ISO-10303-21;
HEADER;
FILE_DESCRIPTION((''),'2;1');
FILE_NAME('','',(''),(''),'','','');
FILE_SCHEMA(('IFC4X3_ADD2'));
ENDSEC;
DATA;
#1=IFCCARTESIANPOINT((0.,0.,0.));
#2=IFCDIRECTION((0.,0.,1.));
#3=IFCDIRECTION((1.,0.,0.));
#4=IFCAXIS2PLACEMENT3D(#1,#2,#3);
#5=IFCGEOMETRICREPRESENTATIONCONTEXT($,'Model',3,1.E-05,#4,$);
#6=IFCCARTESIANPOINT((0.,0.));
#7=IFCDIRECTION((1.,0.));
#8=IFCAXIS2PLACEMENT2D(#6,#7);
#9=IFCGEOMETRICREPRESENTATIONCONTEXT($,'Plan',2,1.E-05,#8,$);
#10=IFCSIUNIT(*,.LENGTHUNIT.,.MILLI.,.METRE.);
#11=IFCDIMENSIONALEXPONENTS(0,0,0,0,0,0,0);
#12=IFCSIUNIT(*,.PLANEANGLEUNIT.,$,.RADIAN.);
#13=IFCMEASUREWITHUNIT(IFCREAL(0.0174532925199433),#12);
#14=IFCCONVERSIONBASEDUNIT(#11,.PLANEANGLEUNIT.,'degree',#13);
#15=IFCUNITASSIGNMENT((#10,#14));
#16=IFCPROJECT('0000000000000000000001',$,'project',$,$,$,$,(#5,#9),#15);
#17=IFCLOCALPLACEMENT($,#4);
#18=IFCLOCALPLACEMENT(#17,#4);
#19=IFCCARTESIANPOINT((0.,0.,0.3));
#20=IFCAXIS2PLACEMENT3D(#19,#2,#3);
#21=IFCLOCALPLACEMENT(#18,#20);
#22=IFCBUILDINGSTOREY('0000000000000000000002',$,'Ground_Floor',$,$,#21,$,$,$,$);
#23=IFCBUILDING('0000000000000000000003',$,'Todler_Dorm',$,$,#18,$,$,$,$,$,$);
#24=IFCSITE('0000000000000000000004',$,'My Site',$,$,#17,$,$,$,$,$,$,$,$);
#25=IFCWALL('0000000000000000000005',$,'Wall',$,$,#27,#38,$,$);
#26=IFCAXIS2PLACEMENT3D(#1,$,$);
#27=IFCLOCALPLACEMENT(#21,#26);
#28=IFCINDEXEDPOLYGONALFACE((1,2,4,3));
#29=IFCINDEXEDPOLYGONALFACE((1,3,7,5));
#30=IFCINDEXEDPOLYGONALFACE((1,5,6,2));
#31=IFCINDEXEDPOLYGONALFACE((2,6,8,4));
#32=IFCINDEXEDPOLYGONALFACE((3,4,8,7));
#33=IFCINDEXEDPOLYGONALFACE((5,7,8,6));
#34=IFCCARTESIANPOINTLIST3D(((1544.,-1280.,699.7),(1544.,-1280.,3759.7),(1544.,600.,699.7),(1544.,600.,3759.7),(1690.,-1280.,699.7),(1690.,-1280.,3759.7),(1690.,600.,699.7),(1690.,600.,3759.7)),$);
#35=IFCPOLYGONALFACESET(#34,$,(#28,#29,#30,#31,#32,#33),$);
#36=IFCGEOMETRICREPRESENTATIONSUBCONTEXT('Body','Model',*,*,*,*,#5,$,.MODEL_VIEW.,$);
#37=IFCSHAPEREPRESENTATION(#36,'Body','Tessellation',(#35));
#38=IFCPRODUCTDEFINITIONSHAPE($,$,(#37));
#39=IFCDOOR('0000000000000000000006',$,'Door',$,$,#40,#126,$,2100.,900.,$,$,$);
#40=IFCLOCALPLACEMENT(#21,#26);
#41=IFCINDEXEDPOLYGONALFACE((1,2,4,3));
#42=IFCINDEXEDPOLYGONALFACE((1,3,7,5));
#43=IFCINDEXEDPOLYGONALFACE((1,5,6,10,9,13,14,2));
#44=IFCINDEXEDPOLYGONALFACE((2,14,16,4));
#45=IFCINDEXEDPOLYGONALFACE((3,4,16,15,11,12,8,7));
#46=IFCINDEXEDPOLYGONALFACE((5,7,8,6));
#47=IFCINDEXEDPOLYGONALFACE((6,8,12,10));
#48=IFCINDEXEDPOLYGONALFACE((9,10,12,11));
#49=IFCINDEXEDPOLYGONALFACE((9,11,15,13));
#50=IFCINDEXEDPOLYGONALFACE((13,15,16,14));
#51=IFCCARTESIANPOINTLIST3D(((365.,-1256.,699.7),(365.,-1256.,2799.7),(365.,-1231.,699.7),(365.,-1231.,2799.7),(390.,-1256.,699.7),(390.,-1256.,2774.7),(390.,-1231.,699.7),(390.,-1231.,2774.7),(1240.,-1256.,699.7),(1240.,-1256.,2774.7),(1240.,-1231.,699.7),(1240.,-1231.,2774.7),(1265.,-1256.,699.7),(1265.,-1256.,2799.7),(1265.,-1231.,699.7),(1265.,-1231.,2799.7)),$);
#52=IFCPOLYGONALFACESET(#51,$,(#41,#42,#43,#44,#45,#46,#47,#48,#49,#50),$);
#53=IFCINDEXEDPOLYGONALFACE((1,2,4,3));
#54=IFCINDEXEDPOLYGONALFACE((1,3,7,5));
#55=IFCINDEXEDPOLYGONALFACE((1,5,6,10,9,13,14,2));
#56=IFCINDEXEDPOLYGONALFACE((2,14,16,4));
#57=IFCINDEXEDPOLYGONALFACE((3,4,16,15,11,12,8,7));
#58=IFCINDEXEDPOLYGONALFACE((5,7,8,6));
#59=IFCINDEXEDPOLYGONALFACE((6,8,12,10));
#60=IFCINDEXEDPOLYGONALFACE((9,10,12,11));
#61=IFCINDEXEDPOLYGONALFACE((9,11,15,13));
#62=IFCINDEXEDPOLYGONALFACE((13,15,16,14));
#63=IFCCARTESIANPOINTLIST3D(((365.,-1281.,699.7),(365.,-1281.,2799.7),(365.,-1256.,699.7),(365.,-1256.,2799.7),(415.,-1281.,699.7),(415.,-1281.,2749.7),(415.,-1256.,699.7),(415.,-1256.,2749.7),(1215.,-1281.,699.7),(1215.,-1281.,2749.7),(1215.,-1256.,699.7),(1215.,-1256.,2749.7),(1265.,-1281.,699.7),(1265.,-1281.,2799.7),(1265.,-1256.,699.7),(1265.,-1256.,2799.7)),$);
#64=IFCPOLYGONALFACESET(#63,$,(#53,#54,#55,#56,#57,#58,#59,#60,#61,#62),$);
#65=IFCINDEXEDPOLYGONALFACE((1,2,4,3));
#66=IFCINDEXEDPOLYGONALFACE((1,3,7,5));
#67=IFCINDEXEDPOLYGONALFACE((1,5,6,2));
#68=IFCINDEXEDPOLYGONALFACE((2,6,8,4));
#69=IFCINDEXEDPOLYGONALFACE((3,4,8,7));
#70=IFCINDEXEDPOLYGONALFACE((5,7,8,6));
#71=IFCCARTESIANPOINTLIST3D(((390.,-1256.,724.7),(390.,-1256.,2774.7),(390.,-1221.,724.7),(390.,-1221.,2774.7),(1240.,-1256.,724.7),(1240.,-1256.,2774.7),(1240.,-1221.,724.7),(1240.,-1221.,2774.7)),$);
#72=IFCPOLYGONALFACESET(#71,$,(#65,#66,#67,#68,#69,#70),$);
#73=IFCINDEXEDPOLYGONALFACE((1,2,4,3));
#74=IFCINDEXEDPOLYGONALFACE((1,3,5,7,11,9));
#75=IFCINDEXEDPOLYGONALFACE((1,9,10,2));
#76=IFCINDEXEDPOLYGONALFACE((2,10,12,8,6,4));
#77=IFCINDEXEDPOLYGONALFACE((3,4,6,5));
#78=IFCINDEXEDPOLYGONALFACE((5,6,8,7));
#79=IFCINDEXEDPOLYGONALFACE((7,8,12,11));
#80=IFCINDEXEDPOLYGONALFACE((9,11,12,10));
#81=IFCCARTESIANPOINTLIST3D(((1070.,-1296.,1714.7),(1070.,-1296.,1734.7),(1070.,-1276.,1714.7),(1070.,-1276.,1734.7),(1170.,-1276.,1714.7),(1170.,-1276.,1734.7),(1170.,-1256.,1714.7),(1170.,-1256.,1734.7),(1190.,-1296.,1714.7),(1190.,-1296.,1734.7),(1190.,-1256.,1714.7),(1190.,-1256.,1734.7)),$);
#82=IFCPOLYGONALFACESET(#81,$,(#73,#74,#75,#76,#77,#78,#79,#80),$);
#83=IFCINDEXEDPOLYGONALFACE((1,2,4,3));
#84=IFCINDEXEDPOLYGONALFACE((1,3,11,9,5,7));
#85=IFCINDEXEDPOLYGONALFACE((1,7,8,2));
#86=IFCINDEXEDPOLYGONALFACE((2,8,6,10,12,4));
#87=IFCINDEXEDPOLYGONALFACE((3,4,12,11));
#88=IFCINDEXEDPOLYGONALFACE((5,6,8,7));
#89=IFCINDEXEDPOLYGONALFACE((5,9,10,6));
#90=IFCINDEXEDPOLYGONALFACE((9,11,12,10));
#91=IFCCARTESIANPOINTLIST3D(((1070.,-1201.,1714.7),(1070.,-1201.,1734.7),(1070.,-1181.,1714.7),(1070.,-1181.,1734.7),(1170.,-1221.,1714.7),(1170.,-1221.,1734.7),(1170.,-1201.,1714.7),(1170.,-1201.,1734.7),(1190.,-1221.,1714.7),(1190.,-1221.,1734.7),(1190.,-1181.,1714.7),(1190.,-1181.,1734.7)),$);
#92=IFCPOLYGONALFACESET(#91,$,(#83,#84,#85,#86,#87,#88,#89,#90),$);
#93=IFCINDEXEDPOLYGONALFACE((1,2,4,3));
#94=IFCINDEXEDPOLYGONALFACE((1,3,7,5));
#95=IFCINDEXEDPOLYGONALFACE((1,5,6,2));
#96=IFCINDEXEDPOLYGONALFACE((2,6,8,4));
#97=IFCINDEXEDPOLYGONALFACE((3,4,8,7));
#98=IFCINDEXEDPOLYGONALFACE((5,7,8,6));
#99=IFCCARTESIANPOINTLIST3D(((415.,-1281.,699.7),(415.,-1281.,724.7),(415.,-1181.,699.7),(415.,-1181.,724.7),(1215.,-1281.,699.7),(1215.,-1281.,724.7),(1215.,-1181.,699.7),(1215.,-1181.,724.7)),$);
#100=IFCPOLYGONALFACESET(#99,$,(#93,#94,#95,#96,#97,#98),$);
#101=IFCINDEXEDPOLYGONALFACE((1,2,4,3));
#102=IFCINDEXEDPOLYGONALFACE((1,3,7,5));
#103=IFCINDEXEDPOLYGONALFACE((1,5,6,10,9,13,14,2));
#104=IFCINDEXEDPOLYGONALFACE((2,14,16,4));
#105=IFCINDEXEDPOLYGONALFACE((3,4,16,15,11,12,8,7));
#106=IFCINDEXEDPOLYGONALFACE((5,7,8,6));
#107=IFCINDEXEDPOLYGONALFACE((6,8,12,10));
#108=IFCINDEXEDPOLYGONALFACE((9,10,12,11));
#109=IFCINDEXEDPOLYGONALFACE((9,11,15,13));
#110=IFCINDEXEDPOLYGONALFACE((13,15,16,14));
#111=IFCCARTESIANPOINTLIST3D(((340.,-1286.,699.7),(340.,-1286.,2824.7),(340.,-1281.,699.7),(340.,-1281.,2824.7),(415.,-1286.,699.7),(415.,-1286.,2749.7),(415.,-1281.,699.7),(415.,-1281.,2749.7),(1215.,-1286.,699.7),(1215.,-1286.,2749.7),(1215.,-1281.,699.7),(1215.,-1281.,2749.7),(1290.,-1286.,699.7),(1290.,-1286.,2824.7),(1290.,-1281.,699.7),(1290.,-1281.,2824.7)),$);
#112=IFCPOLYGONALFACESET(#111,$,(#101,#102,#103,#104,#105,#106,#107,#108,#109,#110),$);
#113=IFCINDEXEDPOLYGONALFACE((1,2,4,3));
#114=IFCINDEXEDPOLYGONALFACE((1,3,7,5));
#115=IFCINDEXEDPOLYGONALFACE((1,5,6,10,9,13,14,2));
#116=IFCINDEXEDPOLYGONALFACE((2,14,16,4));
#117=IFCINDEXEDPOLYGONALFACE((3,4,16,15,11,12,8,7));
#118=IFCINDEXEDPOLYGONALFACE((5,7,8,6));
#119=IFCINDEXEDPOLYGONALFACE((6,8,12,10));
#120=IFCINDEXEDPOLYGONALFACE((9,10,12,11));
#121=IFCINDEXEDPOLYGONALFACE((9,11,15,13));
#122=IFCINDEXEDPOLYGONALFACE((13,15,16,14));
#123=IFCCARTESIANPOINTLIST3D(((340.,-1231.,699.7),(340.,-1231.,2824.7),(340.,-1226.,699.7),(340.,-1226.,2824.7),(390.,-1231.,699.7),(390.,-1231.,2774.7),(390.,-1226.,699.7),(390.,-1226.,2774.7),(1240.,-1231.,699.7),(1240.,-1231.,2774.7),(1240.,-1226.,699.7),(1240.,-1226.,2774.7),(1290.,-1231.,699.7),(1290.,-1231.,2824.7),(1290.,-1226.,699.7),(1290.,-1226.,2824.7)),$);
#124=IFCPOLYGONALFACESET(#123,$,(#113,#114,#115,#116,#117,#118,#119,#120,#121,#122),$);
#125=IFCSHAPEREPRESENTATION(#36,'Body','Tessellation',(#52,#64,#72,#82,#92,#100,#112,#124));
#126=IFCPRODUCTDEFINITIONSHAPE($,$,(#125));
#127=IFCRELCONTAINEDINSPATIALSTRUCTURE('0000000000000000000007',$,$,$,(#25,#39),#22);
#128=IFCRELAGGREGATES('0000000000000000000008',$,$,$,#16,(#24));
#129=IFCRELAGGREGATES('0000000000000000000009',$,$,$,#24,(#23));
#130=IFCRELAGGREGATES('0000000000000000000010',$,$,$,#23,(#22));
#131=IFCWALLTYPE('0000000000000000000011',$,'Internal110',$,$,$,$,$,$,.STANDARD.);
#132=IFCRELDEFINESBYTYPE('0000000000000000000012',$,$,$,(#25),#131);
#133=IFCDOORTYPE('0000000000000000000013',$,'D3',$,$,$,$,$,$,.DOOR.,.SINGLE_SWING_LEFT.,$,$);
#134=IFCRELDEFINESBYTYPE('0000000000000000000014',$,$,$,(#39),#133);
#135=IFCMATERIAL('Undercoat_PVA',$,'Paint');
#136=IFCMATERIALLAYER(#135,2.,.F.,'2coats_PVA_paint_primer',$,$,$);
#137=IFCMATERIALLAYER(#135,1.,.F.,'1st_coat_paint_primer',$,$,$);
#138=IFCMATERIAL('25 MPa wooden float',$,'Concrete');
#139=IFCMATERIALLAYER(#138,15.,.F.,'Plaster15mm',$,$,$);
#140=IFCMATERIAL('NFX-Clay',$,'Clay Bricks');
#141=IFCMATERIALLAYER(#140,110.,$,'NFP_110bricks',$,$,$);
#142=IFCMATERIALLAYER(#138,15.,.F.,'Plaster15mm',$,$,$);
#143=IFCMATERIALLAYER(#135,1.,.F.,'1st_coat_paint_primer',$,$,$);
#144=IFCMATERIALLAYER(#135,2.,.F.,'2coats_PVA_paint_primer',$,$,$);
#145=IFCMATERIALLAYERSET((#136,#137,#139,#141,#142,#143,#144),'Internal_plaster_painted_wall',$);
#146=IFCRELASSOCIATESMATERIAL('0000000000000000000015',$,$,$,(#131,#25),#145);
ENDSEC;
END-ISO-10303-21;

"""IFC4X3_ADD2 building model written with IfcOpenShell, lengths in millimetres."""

from ifc_helpers import new_model, entity, si_unit, converted_unit, frame, origin_with_axes, origin_2d_with_axis, place, context, subcontext, project, spatial, line, indexed_curve, outline, extrude, shape, source, transform, mapped, material, layer, layer_set, layer_usage, type_object, type_shapes, element, save


model = new_model("IFC4X3_ADD2")

# Units and contexts
model_context = context("Model", 3, precision=1e-05, world=origin_with_axes())
plan_context = context("Plan", 2, precision=1e-05, world=origin_2d_with_axis())
body_context_1 = subcontext(model_context, "Body", "Model", "MODEL_VIEW")
body_context_2 = subcontext(plan_context, "Body", "Plan", "PLAN_VIEW")
ifc_project = project(units=[si_unit("LENGTHUNIT", "METRE", prefix="MILLI"), converted_unit("PLANEANGLEUNIT", "degree", entity("IfcReal", 0.0174532925199433), si_unit("PLANEANGLEUNIT", "RADIAN"), dimensions=[0, 0, 0, 0, 0, 0, 0])], contexts=[model_context, plan_context])

# Site, building, storey
site_placement = place(None, origin_with_axes())
site = spatial("IfcSite", under=ifc_project, at=site_placement, Name="My Site")
building_placement = place(site_placement, origin_with_axes())
building = spatial("IfcBuilding", under=site, at=building_placement, Name="Todler_Dorm")
storey_placement = place(building_placement, frame((0.0, 0.0, 0.3), z_axis=(0.0, 0.0, 1.0), x_axis=(1.0, 0.0, 0.0)))
storey = spatial("IfcBuildingStorey", under=building, at=storey_placement, Name="Ground_Floor")

# Wall
ifc_material_1 = material(Name="Undercoat_PVA", Category="Paint")
ifc_layer_1 = layer(ifc_material_1, 2.0, ventilated=False, Name="2coats_PVA_paint_primer")
ifc_layer_2 = layer(ifc_material_1, 1.0, ventilated=False, Name="1st_coat_paint_primer")
ifc_material_2 = material(Name="25 MPa wooden float", Category="Concrete")
ifc_layer_3 = layer(ifc_material_2, 15.0, ventilated=False, Name="Plaster15mm")
ifc_material_3 = material(Name="NFX-Clay", Category="Clay Bricks")
ifc_layer_4 = layer(ifc_material_3, 110.0, Name="NFP_110bricks")
ifc_layer_5 = layer(ifc_material_2, 15.0, ventilated=False, Name="Plaster15mm")
ifc_layer_6 = layer(ifc_material_1, 1.0, ventilated=False, Name="1st_coat_paint_primer")
ifc_layer_7 = layer(ifc_material_1, 2.0, ventilated=False, Name="2coats_PVA_paint_primer")
ifc_layer_set_1 = layer_set([ifc_layer_1, ifc_layer_2, ifc_layer_3, ifc_layer_4, ifc_layer_5, ifc_layer_6, ifc_layer_7], Name="Internal_plaster_painted_wall")
ifc_layer_usage_1 = layer_usage(ifc_layer_set_1, "AXIS2", "POSITIVE", 0.0)
wall_type_1 = type_object("IfcWallType", Name="Internal110", PredefinedType="STANDARD", material=ifc_layer_set_1)
wall_1_placement = place(storey_placement, frame((1690.0, -1280.0, 699.7), z_axis=(0.0, 0.0, 1.0), x_axis=(0.0, 1.0, 0.0)))
element("IfcWall", 1, at=wall_1_placement, inside=storey, type_object=wall_type_1, material=ifc_layer_usage_1, Name="Wall", context=body_context_1, shape_type="SweptSolid", body=[
    extrude(outline(indexed_curve([(0.0, 0.0), (0.0, 146.0), (1880.0, 146.0), (1880.0, 0.0)], segments=[line(1, 2, 3, 4, 1)])), origin_with_axes(), (0.0, 0.0, 1.0), 3060.0),
])

# Door
door_type = type_object("IfcDoorType", Name="D3", OperationType="SINGLE_SWING_LEFT", PredefinedType="DOOR")
shared_shape_1 = source(origin_with_axes(), body_context_1, "Body", "SweptSolid", [
    extrude(outline(indexed_curve([(0.0, 0.0), (0.0, 2100.0), (900.0, 2100.0), (900.0, 0.0), (875.0, 0.0), (875.0, 2075.0), (25.0, 2075.0), (25.0, 0.0)], segments=[line(1, 2, 3, 4, 5, 6, 7, 8, 1)])), frame((0.0, 25.0, 0.0), z_axis=(0.0, -1.0, 0.0), x_axis=(1.0, 0.0, 0.0)), (0.0, 0.0, -1.0), 25.0),
    extrude(outline(indexed_curve([(0.0, 0.0), (0.0, 2100.0), (900.0, 2100.0), (900.0, 0.0), (850.0, 0.0), (850.0, 2050.0), (50.0, 2050.0), (50.0, 0.0)], segments=[line(1, 2, 3, 4, 5, 6, 7, 8, 1)])), frame((0.0, 0.0, 0.0), z_axis=(0.0, -1.0, 0.0), x_axis=(1.0, 0.0, 0.0)), (0.0, 0.0, -1.0), 25.0),
    extrude(outline(indexed_curve([(0.0, 0.0), (850.0, 0.0), (850.0, 35.0), (0.0, 35.0)], segments=[line(1, 2, 3, 4, 1)])), frame((25.0, 25.0, 25.0), z_axis=(0.0, 0.0, 1.0), x_axis=(1.0, 0.0, 0.0)), (0.0, 0.0, 1.0), 2050.0),
    extrude(outline(indexed_curve([(0.0, 0.0), (0.0, -40.0), (-120.0, -40.0), (-120.0, -20.0), (-20.0, -20.0), (-20.0, 0.0)], segments=[line(1, 2, 3, 4, 5, 6, 1)])), frame((825.0, 25.0, 1015.0), z_axis=(0.0, 0.0, 1.0), x_axis=(1.0, 0.0, 0.0)), (0.0, 0.0, 1.0), 20.0),
    extrude(outline(indexed_curve([(0.0, 0.0), (0.0, 40.0), (-120.0, 40.0), (-120.0, 20.0), (-20.0, 20.0), (-20.0, 0.0)], segments=[line(1, 2, 3, 4, 5, 6, 1)])), frame((825.0, 60.0, 1015.0), z_axis=(0.0, 0.0, 1.0), x_axis=(1.0, 0.0, 0.0)), (0.0, 0.0, 1.0), 20.0),
    extrude(outline(indexed_curve([(0.0, 0.0), (800.0, 0.0), (800.0, 100.0), (0.0, 100.0)], segments=[line(1, 2, 3, 4, 1)])), frame((50.0, 0.0, 0.0), z_axis=(0.0, 0.0, 1.0), x_axis=(1.0, 0.0, 0.0)), (0.0, 0.0, 1.0), 25.0),
    extrude(outline(indexed_curve([(0.0, 0.0), (0.0, 2125.0), (950.0, 2125.0), (950.0, 0.0), (875.0, 0.0), (875.0, 2050.0), (75.0, 2050.0), (75.0, 0.0)], segments=[line(1, 2, 3, 4, 5, 6, 7, 8, 1)])), frame((-25.0, -5.0, 0.0), z_axis=(0.0, -1.0, 0.0), x_axis=(1.0, 0.0, 0.0)), (0.0, 0.0, -1.0), 5.0),
    extrude(outline(indexed_curve([(0.0, 0.0), (0.0, 2125.0), (950.0, 2125.0), (950.0, 0.0), (900.0, 0.0), (900.0, 2075.0), (50.0, 2075.0), (50.0, 0.0)], segments=[line(1, 2, 3, 4, 5, 6, 7, 8, 1)])), frame((-25.0, 50.0, 0.0), z_axis=(0.0, -1.0, 0.0), x_axis=(1.0, 0.0, 0.0)), (0.0, 0.0, -1.0), 5.0),
])
shared_shape_2 = source(origin_with_axes(), body_context_2, "Body", "Curve2D", [
    entity("IfcIndexedPolyCurve", entity("IfcCartesianPointList2D", [[0.0, 0.0], [0.0, 50.0], [25.0, 50.0], [25.0, 25.0], [50.0, 25.0], [50.0, 0.0]]), [entity("IfcLineIndex", [1, 2, 3, 4, 5, 6, 1])]),
    entity("IfcIndexedPolyCurve", entity("IfcCartesianPointList2D", [[900.0, 0.0], [900.0, 50.0], [875.0, 50.0], [875.0, 25.0], [850.0, 25.0], [850.0, 0.0]]), [entity("IfcLineIndex", [1, 2, 3, 4, 5, 6, 1])]),
    entity("IfcTrimmedCurve", entity("IfcEllipse", entity("IfcAxis2Placement2D", entity("IfcCartesianPoint", [60.0, 50.0]), entity("IfcDirection", [1.0, 0.0])), 815.0, 850.0), [entity("IfcCartesianPoint", [875.0, 50.0])], [entity("IfcCartesianPoint", [60.0, 900.0])], True, "CARTESIAN"),
    entity("IfcIndexedPolyCurve", entity("IfcCartesianPointList2D", [[25.0, 50.0], [60.0, 50.0], [60.0, 900.0], [25.0, 900.0]]), [entity("IfcLineIndex", [1, 2, 3, 4, 1])]),
])
type_shapes(door_type, [shared_shape_1, shared_shape_2])
door_placement = place(storey_placement, frame((365.0, -1281.0, 699.7), z_axis=(0.0, 0.0, 1.0), x_axis=(1.0, 0.0, 0.0)))
element("IfcDoor", 2, at=door_placement, inside=storey, type_object=door_type, Name="Door", OverallHeight=2100.0, OverallWidth=900.0, shapes=[
    shape(body_context_1, "Body", "MappedRepresentation", [mapped(shared_shape_1, transform((0.0, 0.0, 0.0), x_axis=(1.0, 0.0, 0.0), y_axis=(0.0, 1.0, 0.0), z_axis=(0.0, 0.0, 1.0), scale=1.0))]),
    shape(body_context_2, "Body", "MappedRepresentation", [mapped(shared_shape_2, transform((0.0, 0.0, 0.0), x_axis=(1.0, 0.0, 0.0), y_axis=(0.0, 1.0, 0.0), z_axis=(0.0, 0.0, 1.0), scale=1.0))]),
])

save(model, "model.ifc")
